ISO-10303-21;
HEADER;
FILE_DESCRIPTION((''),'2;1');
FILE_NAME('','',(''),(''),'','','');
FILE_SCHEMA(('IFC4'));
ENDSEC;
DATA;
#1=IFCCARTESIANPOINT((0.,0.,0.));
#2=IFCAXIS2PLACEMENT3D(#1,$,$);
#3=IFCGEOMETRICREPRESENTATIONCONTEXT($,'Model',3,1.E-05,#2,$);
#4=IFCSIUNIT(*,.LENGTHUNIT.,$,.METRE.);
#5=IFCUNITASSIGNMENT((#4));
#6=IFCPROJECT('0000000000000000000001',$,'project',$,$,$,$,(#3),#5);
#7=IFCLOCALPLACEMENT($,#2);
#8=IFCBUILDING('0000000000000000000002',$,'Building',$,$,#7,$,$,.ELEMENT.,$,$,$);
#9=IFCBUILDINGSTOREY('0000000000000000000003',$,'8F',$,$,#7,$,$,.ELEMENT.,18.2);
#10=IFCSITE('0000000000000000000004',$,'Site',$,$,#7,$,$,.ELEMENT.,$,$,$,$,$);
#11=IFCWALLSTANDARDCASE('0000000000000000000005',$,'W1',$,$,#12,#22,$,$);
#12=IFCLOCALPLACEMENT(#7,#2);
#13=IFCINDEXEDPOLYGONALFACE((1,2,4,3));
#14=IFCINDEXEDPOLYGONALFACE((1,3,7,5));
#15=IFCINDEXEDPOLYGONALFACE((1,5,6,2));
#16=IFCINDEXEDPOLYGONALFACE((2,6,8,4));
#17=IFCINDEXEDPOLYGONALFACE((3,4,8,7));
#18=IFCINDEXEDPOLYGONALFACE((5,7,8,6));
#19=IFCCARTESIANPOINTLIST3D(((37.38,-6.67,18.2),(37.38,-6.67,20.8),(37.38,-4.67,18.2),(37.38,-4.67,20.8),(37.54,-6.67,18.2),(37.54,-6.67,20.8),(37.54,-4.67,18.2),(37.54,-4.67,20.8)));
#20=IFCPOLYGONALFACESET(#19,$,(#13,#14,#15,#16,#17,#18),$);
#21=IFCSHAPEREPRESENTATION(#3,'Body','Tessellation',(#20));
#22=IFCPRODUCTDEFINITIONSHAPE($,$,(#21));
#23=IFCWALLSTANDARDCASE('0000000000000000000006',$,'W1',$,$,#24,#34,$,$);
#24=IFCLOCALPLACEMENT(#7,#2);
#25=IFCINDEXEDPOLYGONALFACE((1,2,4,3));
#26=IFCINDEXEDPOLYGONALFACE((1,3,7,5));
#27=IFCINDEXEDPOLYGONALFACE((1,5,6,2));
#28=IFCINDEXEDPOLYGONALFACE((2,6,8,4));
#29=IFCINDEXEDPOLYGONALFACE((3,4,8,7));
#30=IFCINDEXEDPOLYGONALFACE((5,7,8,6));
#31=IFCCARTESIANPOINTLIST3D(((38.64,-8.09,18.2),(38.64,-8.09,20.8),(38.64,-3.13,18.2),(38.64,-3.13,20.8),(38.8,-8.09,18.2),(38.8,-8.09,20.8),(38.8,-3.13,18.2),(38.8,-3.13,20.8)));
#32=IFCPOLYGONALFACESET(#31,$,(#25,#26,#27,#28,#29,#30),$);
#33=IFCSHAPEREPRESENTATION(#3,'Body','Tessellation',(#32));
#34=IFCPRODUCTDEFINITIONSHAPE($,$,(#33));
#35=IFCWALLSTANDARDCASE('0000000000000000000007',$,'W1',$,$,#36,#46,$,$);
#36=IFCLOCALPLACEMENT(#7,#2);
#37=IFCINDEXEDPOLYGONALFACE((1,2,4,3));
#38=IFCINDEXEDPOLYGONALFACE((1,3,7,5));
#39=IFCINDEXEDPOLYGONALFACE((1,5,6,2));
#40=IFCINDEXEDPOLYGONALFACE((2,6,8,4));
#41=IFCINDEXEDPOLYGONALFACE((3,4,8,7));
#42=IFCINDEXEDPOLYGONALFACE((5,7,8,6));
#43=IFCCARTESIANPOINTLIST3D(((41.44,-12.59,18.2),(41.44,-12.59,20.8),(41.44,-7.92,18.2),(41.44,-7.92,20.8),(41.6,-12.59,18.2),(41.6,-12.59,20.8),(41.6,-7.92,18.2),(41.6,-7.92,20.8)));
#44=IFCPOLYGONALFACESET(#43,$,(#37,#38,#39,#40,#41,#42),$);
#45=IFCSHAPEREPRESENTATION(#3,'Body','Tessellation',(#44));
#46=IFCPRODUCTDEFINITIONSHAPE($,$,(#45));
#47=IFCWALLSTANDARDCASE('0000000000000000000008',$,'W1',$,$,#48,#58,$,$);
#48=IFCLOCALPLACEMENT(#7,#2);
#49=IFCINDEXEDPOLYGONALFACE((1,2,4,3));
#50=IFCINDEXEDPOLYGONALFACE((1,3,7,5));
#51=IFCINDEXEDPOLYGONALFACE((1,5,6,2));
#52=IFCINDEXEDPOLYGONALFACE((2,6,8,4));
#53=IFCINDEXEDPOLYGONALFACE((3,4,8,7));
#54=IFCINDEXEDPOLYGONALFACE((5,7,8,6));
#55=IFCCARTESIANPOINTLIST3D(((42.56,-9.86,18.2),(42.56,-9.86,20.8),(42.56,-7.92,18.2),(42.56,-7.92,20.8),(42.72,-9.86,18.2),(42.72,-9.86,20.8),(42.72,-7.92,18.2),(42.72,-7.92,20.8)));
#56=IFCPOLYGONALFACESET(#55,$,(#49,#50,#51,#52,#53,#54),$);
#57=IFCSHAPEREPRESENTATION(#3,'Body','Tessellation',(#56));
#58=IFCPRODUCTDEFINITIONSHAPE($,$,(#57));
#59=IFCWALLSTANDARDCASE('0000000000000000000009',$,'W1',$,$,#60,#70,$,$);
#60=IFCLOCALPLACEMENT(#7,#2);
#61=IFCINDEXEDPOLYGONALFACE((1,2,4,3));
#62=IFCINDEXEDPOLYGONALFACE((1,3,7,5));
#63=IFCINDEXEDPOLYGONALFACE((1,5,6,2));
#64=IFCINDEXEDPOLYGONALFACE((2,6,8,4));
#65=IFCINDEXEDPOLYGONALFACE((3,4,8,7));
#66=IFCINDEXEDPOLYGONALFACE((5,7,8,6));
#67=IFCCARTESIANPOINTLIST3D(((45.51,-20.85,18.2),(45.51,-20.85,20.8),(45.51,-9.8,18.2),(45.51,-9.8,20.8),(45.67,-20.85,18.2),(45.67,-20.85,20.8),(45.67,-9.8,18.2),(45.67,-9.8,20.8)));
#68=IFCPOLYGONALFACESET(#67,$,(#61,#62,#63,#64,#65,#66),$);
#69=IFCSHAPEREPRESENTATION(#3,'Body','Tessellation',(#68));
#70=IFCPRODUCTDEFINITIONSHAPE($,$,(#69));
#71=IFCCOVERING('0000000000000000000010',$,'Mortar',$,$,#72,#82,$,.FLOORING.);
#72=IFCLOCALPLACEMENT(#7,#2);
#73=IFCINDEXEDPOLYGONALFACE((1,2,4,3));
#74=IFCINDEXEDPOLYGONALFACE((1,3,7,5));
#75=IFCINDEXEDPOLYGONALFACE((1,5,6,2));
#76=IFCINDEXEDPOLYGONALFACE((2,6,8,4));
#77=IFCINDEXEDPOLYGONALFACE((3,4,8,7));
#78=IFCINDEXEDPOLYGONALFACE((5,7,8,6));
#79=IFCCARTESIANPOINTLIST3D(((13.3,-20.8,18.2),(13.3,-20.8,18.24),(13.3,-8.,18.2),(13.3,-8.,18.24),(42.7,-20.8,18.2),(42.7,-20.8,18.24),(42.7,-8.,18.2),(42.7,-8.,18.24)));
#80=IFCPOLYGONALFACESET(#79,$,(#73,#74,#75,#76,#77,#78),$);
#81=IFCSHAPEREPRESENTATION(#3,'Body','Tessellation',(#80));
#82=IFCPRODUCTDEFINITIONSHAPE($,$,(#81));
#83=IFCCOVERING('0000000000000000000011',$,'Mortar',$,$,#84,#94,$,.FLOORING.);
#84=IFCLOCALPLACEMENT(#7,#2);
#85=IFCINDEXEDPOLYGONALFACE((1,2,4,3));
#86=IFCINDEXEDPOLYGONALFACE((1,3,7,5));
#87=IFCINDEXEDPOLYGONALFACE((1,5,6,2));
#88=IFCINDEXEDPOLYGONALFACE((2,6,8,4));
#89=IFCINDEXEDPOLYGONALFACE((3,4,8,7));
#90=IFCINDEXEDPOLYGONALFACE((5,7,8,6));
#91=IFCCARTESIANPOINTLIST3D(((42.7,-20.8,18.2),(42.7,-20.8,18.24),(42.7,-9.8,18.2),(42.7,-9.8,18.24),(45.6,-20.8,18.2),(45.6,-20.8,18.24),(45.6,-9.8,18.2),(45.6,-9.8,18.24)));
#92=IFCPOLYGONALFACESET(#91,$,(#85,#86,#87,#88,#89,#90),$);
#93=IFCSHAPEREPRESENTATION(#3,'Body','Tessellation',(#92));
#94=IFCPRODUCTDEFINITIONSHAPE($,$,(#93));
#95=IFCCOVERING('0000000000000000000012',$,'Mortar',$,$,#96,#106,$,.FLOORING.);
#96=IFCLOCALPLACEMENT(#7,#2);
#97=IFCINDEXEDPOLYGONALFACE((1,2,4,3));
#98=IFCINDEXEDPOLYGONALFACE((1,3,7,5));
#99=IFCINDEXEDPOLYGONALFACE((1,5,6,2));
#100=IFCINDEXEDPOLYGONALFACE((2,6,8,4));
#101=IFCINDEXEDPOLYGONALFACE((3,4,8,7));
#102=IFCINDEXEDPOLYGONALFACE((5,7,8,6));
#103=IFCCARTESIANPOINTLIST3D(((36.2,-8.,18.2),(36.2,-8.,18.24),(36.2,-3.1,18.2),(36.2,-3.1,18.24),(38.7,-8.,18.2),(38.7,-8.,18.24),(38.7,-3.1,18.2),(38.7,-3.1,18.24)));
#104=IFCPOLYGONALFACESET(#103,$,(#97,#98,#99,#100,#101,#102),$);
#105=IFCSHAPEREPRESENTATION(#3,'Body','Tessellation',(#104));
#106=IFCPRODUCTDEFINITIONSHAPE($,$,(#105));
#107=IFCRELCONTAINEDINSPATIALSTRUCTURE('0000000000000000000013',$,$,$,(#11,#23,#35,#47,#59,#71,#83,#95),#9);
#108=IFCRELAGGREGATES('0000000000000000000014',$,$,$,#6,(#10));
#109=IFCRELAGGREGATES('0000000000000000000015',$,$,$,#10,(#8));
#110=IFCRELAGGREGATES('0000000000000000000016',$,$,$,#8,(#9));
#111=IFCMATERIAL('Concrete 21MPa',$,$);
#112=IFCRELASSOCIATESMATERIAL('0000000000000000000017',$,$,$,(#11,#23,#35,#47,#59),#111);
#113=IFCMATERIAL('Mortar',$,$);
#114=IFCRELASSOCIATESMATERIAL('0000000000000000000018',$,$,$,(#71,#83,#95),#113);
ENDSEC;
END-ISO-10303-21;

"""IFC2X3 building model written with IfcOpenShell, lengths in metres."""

from ifc_helpers import new_model, si_unit, frame, origin, origin_2d, place, context, project, spatial, rectangle, extrude, material, element, save


model = new_model("IFC2X3")

# Units and contexts
model_context = context("Model", 3, precision=1e-05, world=origin())
ifc_project = project(units=[si_unit("LENGTHUNIT", "METRE")], contexts=[model_context])

# Site, building, storey
placement = place(None, origin())
site = spatial("IfcSite", under=ifc_project, at=placement, Name="Site", CompositionType="ELEMENT")
building = spatial("IfcBuilding", under=site, at=placement, Name="Building", CompositionType="ELEMENT")
storey = spatial("IfcBuildingStorey", under=building, at=placement, Name="8F", CompositionType="ELEMENT", Elevation=18.2)

# Shared definitions
ifc_material_1 = material(Name="Concrete 21MPa")

# Walls
wall_1_placement = place(None, frame((37.46, -5.67, 18.2)))
element("IfcWallStandardCase", 1, at=wall_1_placement, inside=storey, material=ifc_material_1, Name="W1", context=model_context, shape_type="SweptSolid", body=[
    extrude(rectangle(XDim=0.16, YDim=2.0, at=origin_2d()), origin(), (0.0, 0.0, 1.0), 2.6),
])
wall_2_placement = place(None, frame((38.72, -5.61, 18.2)))
element("IfcWallStandardCase", 2, at=wall_2_placement, inside=storey, material=ifc_material_1, Name="W1", context=model_context, shape_type="SweptSolid", body=[
    extrude(rectangle(XDim=0.16, YDim=4.96, at=origin_2d()), origin(), (0.0, 0.0, 1.0), 2.6),
])
wall_3_placement = place(None, frame((41.52, -10.255, 18.2)))
element("IfcWallStandardCase", 3, at=wall_3_placement, inside=storey, material=ifc_material_1, Name="W1", context=model_context, shape_type="SweptSolid", body=[
    extrude(rectangle(XDim=0.16, YDim=4.67, at=origin_2d()), origin(), (0.0, 0.0, 1.0), 2.6),
])
wall_4_placement = place(None, frame((42.64, -8.89, 18.2)))
element("IfcWallStandardCase", 4, at=wall_4_placement, inside=storey, material=ifc_material_1, Name="W1", context=model_context, shape_type="SweptSolid", body=[
    extrude(rectangle(XDim=0.16, YDim=1.94, at=origin_2d()), origin(), (0.0, 0.0, 1.0), 2.6),
])
wall_5_placement = place(None, frame((45.59, -15.325, 18.2)))
element("IfcWallStandardCase", 5, at=wall_5_placement, inside=storey, material=ifc_material_1, Name="W1", context=model_context, shape_type="SweptSolid", body=[
    extrude(rectangle(XDim=0.16, YDim=11.05, at=origin_2d()), origin(), (0.0, 0.0, 1.0), 2.6),
])

# Coverings
ifc_material_2 = material(Name="Mortar")
covering_1_placement = place(None, frame((28.0, -14.4, 18.2)))
element("IfcCovering", 6, at=covering_1_placement, inside=storey, material=ifc_material_2, Name="Mortar", PredefinedType="FLOORING", context=model_context, shape_type="SweptSolid", body=[
    extrude(rectangle(XDim=29.4, YDim=12.8, at=origin_2d()), origin(), (0.0, 0.0, 1.0), 0.04),
])
covering_2_placement = place(None, frame((44.15, -15.3, 18.2)))
element("IfcCovering", 7, at=covering_2_placement, inside=storey, material=ifc_material_2, Name="Mortar", PredefinedType="FLOORING", context=model_context, shape_type="SweptSolid", body=[
    extrude(rectangle(XDim=2.9, YDim=11.0, at=origin_2d()), origin(), (0.0, 0.0, 1.0), 0.04),
])
covering_3_placement = place(None, frame((37.45, -5.55, 18.2)))
element("IfcCovering", 8, at=covering_3_placement, inside=storey, material=ifc_material_2, Name="Mortar", PredefinedType="FLOORING", context=model_context, shape_type="SweptSolid", body=[
    extrude(rectangle(XDim=2.5, YDim=4.9, at=origin_2d()), origin(), (0.0, 0.0, 1.0), 0.04),
])

save(model, "model.ifc")
